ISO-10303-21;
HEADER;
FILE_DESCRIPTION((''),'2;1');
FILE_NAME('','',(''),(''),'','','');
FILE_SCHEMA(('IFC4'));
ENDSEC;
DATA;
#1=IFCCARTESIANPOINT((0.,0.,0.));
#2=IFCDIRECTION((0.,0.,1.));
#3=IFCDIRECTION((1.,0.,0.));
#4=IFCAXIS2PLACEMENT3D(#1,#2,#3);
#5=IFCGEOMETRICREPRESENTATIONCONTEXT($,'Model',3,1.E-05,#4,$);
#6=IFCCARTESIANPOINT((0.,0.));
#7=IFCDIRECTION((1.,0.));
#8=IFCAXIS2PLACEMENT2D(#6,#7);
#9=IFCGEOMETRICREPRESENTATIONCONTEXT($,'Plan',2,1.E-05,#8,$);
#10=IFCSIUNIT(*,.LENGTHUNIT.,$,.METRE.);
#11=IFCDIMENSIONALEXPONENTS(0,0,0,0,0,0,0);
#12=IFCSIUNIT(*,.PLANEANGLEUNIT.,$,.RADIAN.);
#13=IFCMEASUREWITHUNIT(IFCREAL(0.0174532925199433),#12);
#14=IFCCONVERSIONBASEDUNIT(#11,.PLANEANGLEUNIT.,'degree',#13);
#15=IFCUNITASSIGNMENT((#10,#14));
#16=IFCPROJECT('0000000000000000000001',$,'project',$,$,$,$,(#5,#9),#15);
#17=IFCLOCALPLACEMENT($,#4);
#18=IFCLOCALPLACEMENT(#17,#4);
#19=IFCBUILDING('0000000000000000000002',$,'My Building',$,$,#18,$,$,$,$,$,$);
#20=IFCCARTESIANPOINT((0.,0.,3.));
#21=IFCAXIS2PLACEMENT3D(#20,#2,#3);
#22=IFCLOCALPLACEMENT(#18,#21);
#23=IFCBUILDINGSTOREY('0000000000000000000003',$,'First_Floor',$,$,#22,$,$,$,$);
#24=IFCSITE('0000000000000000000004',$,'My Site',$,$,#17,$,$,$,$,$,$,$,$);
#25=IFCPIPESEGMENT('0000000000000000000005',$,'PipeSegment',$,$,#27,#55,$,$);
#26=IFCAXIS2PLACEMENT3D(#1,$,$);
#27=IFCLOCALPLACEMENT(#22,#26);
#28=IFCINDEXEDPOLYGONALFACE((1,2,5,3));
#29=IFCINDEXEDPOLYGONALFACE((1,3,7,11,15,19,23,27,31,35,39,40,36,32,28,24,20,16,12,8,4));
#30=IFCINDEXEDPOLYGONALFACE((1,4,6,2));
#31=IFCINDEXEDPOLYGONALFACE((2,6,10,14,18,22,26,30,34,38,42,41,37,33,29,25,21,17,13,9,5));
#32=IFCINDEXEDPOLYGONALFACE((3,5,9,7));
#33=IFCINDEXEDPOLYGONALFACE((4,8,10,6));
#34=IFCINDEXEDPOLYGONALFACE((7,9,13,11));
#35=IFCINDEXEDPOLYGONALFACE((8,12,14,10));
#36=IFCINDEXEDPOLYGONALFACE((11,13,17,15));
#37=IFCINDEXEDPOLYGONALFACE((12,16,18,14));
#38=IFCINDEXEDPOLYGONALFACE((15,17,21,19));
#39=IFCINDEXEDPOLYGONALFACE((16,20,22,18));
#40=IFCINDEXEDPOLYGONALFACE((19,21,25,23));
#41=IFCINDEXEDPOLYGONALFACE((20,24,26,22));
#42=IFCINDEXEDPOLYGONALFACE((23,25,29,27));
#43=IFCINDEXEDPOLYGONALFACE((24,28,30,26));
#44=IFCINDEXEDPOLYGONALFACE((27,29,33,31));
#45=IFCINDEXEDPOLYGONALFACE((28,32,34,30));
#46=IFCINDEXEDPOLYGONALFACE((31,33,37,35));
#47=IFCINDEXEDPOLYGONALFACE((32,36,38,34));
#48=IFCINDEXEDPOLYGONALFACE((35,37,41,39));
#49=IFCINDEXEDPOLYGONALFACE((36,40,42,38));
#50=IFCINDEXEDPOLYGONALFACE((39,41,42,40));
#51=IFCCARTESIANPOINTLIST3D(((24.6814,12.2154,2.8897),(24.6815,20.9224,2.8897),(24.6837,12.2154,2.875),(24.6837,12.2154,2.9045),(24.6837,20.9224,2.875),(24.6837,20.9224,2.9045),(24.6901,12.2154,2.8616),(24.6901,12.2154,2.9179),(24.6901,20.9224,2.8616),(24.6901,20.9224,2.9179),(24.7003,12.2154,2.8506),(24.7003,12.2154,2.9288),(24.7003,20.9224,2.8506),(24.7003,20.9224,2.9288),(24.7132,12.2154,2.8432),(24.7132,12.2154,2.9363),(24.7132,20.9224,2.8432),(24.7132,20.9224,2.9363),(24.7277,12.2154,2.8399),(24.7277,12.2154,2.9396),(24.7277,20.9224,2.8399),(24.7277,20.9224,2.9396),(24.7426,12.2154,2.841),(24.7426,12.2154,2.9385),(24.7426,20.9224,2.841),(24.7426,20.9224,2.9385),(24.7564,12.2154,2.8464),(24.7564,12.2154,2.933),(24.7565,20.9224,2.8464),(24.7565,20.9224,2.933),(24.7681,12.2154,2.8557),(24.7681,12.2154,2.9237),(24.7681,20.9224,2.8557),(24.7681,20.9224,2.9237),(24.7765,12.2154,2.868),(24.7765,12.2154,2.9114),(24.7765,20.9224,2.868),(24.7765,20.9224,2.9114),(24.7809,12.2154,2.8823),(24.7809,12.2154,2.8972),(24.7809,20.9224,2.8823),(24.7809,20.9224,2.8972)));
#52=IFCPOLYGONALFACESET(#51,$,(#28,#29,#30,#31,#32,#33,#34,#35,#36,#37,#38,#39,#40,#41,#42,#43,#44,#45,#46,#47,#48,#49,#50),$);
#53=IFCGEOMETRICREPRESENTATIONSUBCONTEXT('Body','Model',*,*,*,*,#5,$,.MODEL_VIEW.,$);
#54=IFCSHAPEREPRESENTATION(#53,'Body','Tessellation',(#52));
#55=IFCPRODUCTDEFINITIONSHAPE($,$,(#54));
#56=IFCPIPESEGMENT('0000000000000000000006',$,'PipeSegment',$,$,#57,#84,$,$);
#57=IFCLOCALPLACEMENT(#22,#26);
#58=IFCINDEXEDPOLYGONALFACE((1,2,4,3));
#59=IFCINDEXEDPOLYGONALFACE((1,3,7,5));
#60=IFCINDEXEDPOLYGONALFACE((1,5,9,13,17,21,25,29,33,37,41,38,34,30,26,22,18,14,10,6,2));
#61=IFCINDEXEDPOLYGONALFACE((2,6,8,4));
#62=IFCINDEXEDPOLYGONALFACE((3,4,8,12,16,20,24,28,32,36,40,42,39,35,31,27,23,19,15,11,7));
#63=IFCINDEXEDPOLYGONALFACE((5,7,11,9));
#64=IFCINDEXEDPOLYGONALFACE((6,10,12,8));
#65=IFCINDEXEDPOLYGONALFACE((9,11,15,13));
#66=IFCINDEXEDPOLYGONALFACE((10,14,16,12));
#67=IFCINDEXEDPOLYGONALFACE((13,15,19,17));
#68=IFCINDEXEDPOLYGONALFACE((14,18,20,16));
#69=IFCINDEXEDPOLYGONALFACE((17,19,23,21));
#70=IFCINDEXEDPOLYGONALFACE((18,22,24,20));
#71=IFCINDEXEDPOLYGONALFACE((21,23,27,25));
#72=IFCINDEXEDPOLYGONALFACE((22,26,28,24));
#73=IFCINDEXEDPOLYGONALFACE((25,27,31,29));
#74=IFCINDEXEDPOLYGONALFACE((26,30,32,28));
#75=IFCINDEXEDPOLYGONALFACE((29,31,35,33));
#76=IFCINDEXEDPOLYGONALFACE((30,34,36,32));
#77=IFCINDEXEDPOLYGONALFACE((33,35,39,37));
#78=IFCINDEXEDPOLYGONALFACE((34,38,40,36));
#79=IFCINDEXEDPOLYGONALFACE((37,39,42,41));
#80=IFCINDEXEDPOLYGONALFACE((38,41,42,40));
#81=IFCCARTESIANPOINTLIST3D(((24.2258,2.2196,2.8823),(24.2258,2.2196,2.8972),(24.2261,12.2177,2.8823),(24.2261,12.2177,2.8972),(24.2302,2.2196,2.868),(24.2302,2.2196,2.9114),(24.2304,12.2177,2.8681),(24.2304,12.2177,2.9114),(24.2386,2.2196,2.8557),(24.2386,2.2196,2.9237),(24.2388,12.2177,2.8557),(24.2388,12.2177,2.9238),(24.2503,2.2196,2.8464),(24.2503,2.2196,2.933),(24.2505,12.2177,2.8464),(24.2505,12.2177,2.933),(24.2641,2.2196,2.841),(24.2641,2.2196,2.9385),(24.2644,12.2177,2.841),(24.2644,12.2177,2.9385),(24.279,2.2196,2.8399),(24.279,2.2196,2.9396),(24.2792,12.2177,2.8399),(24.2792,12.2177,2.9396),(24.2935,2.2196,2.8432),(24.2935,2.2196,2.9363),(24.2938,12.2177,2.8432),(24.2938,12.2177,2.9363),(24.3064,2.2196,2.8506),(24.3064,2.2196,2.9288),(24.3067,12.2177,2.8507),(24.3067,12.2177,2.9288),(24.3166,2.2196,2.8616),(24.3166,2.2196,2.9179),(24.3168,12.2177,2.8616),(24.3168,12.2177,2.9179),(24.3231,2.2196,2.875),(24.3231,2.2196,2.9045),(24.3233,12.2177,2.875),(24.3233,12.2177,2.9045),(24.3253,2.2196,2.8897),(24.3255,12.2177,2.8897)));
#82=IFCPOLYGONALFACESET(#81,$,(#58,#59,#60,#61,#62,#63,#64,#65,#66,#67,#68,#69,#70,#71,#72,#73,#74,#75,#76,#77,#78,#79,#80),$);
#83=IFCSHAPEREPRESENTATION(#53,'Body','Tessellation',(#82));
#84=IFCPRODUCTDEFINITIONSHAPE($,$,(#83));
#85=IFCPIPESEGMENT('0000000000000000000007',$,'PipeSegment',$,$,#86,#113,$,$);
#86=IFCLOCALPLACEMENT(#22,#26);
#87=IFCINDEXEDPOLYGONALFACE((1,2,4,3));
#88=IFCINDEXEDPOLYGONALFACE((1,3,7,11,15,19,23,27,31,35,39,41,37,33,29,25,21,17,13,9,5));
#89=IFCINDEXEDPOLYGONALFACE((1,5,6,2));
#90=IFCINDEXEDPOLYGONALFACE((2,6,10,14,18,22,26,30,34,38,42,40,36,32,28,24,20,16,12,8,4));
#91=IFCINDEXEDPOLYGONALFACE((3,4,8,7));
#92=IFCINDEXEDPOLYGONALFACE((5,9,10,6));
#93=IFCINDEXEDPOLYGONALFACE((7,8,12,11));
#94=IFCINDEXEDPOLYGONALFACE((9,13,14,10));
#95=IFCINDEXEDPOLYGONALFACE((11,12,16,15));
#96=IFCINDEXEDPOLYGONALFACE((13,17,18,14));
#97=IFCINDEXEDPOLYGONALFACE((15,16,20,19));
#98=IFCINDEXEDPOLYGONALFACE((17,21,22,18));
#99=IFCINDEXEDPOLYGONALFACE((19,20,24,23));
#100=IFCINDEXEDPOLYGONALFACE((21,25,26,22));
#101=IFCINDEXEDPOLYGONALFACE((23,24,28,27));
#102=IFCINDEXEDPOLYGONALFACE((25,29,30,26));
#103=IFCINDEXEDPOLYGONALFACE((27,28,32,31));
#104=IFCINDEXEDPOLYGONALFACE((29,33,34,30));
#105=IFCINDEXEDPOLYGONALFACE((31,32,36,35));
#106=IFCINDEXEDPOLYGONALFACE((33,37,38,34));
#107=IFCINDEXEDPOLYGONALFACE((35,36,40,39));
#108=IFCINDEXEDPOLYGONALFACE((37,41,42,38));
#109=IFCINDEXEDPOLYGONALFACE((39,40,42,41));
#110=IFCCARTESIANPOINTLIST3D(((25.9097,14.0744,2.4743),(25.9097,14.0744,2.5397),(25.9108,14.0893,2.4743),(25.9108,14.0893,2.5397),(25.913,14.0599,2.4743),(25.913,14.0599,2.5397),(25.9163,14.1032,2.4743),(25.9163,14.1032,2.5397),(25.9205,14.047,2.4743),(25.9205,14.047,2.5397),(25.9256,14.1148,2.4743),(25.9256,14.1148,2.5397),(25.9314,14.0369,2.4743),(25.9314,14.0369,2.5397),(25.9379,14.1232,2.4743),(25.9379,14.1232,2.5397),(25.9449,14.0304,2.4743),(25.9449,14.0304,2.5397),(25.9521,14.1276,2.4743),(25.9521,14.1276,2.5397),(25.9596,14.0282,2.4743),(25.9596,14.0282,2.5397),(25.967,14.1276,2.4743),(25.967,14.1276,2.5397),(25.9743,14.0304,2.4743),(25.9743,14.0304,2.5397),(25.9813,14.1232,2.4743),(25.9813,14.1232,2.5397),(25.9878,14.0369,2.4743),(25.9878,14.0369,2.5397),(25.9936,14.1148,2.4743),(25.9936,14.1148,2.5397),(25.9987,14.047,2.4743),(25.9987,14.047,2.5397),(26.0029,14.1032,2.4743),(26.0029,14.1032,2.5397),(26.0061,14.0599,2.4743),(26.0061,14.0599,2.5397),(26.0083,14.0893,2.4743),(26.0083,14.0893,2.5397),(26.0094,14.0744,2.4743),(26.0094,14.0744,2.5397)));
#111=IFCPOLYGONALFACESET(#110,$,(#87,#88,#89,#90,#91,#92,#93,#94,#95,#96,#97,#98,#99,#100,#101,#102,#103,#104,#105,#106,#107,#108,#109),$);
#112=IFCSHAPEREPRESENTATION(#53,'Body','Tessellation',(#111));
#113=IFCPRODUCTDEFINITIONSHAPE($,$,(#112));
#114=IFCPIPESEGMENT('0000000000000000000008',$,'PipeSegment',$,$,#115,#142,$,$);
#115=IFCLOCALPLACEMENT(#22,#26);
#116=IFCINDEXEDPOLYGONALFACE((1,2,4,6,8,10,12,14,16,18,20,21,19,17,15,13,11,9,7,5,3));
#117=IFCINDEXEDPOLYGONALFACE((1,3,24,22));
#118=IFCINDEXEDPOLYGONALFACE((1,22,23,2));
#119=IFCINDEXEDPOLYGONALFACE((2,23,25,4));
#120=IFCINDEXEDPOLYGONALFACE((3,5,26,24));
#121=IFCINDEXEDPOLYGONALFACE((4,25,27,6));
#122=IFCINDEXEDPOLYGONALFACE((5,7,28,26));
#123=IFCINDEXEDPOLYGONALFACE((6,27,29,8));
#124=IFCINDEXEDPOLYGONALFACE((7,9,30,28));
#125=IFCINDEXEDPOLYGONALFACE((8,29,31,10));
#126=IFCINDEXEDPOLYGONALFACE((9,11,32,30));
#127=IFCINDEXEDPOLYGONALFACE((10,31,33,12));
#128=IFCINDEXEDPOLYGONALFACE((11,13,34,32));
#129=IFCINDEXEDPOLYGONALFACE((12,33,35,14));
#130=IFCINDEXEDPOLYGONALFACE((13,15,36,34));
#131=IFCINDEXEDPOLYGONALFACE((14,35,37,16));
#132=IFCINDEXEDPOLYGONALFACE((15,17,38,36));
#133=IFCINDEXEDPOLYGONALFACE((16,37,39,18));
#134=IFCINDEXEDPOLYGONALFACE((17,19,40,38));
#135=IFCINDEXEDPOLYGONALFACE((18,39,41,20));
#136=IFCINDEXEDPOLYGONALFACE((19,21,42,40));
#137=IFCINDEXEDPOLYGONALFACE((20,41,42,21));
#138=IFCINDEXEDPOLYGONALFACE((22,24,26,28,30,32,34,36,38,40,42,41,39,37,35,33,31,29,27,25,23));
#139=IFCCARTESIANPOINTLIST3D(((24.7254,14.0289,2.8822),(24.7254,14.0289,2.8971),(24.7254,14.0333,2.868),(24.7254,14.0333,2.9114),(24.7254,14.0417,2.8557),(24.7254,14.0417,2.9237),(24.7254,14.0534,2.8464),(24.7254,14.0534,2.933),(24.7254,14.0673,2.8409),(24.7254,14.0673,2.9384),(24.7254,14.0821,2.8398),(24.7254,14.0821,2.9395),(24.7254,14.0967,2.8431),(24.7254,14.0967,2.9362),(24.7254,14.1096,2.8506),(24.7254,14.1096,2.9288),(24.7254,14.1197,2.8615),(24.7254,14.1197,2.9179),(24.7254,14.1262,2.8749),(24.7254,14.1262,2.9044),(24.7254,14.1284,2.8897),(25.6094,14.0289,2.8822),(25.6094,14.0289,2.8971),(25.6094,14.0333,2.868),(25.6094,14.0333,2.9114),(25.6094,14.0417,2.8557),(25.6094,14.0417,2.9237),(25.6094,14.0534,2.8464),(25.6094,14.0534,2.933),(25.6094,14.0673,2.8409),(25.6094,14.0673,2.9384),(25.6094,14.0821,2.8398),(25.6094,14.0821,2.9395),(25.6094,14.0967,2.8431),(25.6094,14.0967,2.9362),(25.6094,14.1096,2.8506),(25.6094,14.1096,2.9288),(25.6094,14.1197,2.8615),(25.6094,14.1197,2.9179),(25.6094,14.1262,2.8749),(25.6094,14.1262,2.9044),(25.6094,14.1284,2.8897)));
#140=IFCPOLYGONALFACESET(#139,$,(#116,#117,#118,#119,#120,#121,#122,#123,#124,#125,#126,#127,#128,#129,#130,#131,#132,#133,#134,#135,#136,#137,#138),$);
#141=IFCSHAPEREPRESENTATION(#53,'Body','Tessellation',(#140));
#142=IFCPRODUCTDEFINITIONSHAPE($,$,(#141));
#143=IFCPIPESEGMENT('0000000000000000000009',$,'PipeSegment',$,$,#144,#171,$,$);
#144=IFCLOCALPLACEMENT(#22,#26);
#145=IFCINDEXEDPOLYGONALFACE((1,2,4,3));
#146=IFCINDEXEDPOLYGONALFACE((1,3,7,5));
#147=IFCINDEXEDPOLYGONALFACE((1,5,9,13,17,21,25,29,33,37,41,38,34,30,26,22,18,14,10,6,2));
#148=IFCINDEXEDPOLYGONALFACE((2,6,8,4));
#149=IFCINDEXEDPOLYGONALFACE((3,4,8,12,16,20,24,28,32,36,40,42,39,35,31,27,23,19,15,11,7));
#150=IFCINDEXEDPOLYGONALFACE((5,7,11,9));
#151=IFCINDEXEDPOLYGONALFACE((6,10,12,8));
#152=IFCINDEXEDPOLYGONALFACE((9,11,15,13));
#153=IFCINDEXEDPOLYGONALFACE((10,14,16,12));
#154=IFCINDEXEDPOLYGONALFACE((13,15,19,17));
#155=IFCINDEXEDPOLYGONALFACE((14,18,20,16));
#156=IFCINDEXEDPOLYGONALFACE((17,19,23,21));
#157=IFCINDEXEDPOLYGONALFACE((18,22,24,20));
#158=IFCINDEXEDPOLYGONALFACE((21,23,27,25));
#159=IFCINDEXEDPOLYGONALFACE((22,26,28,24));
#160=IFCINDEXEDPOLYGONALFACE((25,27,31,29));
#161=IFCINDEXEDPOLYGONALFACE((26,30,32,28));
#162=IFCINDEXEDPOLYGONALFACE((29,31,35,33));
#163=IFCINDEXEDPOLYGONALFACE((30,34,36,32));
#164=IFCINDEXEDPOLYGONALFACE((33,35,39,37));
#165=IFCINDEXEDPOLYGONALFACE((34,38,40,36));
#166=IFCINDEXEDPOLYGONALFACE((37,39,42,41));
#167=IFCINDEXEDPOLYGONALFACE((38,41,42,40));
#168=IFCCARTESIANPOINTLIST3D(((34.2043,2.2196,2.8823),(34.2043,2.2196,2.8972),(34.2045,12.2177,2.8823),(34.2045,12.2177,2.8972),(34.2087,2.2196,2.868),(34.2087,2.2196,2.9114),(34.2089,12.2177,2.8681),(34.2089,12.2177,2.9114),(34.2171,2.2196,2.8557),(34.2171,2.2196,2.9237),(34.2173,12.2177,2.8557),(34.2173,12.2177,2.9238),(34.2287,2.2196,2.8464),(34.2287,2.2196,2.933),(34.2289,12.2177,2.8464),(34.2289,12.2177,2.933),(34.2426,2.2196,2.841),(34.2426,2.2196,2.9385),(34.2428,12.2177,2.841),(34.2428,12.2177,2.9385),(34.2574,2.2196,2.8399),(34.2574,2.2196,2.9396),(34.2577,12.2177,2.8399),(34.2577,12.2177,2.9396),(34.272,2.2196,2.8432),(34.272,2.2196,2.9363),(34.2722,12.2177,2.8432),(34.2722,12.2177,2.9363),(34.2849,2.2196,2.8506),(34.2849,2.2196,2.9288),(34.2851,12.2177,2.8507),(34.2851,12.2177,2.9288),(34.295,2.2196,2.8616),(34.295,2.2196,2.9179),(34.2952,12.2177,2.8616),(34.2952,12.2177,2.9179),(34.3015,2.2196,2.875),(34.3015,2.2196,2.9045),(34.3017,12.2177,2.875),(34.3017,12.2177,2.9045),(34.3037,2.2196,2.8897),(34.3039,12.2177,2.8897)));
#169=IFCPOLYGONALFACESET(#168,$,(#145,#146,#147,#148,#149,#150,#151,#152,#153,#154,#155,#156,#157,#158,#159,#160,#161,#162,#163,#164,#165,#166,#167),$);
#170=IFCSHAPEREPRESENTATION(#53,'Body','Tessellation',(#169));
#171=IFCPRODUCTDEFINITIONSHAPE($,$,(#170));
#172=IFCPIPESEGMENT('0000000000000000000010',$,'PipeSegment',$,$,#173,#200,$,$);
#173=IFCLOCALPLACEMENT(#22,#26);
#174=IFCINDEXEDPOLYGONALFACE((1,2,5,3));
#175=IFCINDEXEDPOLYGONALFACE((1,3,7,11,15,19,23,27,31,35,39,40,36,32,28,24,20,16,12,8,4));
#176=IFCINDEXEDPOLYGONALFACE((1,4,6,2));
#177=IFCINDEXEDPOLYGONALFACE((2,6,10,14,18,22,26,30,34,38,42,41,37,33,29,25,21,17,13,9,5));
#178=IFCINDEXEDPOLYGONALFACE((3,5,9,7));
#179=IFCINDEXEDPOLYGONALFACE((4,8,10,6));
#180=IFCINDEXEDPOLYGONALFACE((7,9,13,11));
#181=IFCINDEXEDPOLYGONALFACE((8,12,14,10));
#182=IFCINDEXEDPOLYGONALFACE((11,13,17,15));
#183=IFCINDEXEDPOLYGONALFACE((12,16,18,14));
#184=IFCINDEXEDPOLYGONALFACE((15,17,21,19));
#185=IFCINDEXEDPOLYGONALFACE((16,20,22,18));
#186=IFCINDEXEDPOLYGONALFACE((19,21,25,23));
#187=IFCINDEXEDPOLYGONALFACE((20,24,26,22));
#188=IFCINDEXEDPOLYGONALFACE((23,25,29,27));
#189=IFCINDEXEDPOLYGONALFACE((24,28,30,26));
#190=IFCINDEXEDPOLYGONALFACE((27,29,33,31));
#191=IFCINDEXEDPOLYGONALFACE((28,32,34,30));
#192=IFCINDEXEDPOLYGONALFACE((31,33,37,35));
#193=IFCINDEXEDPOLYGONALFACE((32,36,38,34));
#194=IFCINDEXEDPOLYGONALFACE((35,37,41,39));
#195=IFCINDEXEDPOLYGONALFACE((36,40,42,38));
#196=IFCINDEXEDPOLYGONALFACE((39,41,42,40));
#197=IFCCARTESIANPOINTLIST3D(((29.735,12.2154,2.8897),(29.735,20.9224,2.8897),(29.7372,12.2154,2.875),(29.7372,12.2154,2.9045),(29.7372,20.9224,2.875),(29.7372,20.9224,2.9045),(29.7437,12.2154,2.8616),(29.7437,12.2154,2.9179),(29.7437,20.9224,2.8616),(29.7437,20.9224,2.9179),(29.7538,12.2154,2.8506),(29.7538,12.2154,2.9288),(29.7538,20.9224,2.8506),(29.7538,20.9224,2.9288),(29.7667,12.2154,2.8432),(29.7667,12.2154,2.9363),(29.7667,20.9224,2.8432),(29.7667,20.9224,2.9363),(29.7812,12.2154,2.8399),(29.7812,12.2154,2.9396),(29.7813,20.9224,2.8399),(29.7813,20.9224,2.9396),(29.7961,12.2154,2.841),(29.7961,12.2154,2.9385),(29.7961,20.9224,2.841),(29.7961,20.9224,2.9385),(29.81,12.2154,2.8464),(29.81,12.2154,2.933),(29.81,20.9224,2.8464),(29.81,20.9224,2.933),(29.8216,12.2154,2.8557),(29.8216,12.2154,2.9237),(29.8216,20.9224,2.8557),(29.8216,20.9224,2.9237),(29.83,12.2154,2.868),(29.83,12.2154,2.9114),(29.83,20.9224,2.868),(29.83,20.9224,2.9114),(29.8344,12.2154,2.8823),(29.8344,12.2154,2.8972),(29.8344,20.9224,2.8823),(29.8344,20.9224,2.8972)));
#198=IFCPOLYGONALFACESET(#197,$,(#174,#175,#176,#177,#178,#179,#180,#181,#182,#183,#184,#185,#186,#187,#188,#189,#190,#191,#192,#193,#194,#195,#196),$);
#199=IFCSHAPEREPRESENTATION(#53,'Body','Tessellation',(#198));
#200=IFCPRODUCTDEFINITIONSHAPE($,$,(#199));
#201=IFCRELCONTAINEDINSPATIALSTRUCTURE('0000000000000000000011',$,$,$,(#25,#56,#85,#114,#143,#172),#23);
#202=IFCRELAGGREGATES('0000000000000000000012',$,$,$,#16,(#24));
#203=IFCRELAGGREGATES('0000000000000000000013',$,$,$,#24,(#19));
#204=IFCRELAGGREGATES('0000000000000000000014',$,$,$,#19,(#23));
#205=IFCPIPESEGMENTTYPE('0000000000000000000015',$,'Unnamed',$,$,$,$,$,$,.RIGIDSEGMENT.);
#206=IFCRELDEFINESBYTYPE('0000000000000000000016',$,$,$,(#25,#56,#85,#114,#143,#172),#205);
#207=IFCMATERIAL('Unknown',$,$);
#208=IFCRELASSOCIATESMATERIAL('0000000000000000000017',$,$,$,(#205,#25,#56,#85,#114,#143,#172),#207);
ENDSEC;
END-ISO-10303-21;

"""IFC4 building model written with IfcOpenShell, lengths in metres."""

from ifc_helpers import new_model, entity, si_unit, converted_unit, frame, origin_with_axes, origin_2d_with_axis, place, context, subcontext, project, spatial, circle, extrude, material, material_profile, profile_set, profile_usage, type_object, element, save


model = new_model("IFC4")

# Units and contexts
model_context = context("Model", 3, precision=1e-05, world=origin_with_axes())
plan_context = context("Plan", 2, precision=1e-05, world=origin_2d_with_axis())
body_context_1 = subcontext(model_context, "Body", "Model", "MODEL_VIEW")
ifc_project = project(units=[si_unit("LENGTHUNIT", "METRE"), converted_unit("PLANEANGLEUNIT", "degree", entity("IfcReal", 0.0174532925199433), si_unit("PLANEANGLEUNIT", "RADIAN"), dimensions=[0, 0, 0, 0, 0, 0, 0])], contexts=[model_context, plan_context])

# Site, building, storey
site_placement = place(None, origin_with_axes())
site = spatial("IfcSite", under=ifc_project, at=site_placement, Name="My Site")
building_placement = place(site_placement, origin_with_axes())
building = spatial("IfcBuilding", under=site, at=building_placement, Name="My Building")
storey_placement = place(building_placement, frame((0.0, 0.0, 3.0), z_axis=(0.0, 0.0, 1.0), x_axis=(1.0, 0.0, 0.0)))
storey = spatial("IfcBuildingStorey", under=building, at=storey_placement, Name="First_Floor")

# Shared definitions
ifc_material = material(Name="Unknown")

# Pipe segments
ifc_material_profile_1 = material_profile(ifc_material, circle(Radius=0.05))
ifc_profile_set_1 = profile_set([ifc_material_profile_1])
ifc_profile_usage_1 = profile_usage(ifc_profile_set_1, cardinal=5)
pipe_segment_type = type_object("IfcPipeSegmentType", Name="Unnamed", PredefinedType="RIGIDSEGMENT", material=ifc_profile_set_1)
pipe_segment_1_placement = place(storey_placement, frame((24.7314, 12.2154, 2.8897), z_axis=(0.0, 1.0, 0.0), x_axis=(-1.0, 0.0, 0.0)))
element("IfcPipeSegment", 1, at=pipe_segment_1_placement, inside=storey, type_object=pipe_segment_type, material=ifc_profile_usage_1, Name="PipeSegment", context=body_context_1, shape_type="SweptSolid", body=[
    extrude(circle(Radius=0.05), origin_with_axes(), (0.0, 0.0, 1.0), 8.707),
])
ifc_profile_usage_2 = profile_usage(ifc_profile_set_1, cardinal=5)
pipe_segment_2_placement = place(storey_placement, frame((24.2755, 12.2177, 2.8897), z_axis=(-0.000022, -1.0, -0.000003), x_axis=(1.0, -0.000022, 0.0)))
element("IfcPipeSegment", 2, at=pipe_segment_2_placement, inside=storey, type_object=pipe_segment_type, material=ifc_profile_usage_2, Name="PipeSegment", context=body_context_1, shape_type="SweptSolid", body=[
    extrude(circle(Radius=0.05), origin_with_axes(), (0.0, 0.0, 1.0), 9.9981),
])
ifc_profile_usage_3 = profile_usage(ifc_profile_set_1, cardinal=5)
pipe_segment_3_placement = place(storey_placement, frame((25.9596, 14.0782, 2.4743), z_axis=(0.0, 0.0, 1.0), x_axis=(0.0, -1.0, 0.0)))
element("IfcPipeSegment", 3, at=pipe_segment_3_placement, inside=storey, type_object=pipe_segment_type, material=ifc_profile_usage_3, Name="PipeSegment", context=body_context_1, shape_type="SweptSolid", body=[
    extrude(circle(Radius=0.05), origin_with_axes(), (0.0, 0.0, 1.0), 0.0654),
])
ifc_profile_usage_4 = profile_usage(ifc_profile_set_1, cardinal=5)
pipe_segment_4_placement = place(storey_placement, frame((24.7254, 14.0784, 2.8897), z_axis=(1.0, 0.0, 0.0), x_axis=(0.0, 1.0, 0.0)))
element("IfcPipeSegment", 4, at=pipe_segment_4_placement, inside=storey, type_object=pipe_segment_type, material=ifc_profile_usage_4, Name="PipeSegment", context=body_context_1, shape_type="SweptSolid", body=[
    extrude(circle(Radius=0.05), origin_with_axes(), (0.0, 0.0, 1.0), 0.884),
])
ifc_profile_usage_5 = profile_usage(ifc_profile_set_1, cardinal=5)
pipe_segment_5_placement = place(storey_placement, frame((34.2539, 12.2177, 2.8897), z_axis=(-0.000022, -1.0, -0.000003), x_axis=(1.0, -0.000022, 0.0)))
element("IfcPipeSegment", 5, at=pipe_segment_5_placement, inside=storey, type_object=pipe_segment_type, material=ifc_profile_usage_5, Name="PipeSegment", context=body_context_1, shape_type="SweptSolid", body=[
    extrude(circle(Radius=0.05), origin_with_axes(), (0.0, 0.0, 1.0), 9.9981),
])
ifc_profile_usage_6 = profile_usage(ifc_profile_set_1, cardinal=5)
pipe_segment_6_placement = place(storey_placement, frame((29.785, 12.2154, 2.8897), z_axis=(0.0, 1.0, 0.0), x_axis=(-1.0, 0.0, 0.0)))
element("IfcPipeSegment", 6, at=pipe_segment_6_placement, inside=storey, type_object=pipe_segment_type, material=ifc_profile_usage_6, Name="PipeSegment", context=body_context_1, shape_type="SweptSolid", body=[
    extrude(circle(Radius=0.05), origin_with_axes(), (0.0, 0.0, 1.0), 8.707),
])

save(model, "model.ifc")
